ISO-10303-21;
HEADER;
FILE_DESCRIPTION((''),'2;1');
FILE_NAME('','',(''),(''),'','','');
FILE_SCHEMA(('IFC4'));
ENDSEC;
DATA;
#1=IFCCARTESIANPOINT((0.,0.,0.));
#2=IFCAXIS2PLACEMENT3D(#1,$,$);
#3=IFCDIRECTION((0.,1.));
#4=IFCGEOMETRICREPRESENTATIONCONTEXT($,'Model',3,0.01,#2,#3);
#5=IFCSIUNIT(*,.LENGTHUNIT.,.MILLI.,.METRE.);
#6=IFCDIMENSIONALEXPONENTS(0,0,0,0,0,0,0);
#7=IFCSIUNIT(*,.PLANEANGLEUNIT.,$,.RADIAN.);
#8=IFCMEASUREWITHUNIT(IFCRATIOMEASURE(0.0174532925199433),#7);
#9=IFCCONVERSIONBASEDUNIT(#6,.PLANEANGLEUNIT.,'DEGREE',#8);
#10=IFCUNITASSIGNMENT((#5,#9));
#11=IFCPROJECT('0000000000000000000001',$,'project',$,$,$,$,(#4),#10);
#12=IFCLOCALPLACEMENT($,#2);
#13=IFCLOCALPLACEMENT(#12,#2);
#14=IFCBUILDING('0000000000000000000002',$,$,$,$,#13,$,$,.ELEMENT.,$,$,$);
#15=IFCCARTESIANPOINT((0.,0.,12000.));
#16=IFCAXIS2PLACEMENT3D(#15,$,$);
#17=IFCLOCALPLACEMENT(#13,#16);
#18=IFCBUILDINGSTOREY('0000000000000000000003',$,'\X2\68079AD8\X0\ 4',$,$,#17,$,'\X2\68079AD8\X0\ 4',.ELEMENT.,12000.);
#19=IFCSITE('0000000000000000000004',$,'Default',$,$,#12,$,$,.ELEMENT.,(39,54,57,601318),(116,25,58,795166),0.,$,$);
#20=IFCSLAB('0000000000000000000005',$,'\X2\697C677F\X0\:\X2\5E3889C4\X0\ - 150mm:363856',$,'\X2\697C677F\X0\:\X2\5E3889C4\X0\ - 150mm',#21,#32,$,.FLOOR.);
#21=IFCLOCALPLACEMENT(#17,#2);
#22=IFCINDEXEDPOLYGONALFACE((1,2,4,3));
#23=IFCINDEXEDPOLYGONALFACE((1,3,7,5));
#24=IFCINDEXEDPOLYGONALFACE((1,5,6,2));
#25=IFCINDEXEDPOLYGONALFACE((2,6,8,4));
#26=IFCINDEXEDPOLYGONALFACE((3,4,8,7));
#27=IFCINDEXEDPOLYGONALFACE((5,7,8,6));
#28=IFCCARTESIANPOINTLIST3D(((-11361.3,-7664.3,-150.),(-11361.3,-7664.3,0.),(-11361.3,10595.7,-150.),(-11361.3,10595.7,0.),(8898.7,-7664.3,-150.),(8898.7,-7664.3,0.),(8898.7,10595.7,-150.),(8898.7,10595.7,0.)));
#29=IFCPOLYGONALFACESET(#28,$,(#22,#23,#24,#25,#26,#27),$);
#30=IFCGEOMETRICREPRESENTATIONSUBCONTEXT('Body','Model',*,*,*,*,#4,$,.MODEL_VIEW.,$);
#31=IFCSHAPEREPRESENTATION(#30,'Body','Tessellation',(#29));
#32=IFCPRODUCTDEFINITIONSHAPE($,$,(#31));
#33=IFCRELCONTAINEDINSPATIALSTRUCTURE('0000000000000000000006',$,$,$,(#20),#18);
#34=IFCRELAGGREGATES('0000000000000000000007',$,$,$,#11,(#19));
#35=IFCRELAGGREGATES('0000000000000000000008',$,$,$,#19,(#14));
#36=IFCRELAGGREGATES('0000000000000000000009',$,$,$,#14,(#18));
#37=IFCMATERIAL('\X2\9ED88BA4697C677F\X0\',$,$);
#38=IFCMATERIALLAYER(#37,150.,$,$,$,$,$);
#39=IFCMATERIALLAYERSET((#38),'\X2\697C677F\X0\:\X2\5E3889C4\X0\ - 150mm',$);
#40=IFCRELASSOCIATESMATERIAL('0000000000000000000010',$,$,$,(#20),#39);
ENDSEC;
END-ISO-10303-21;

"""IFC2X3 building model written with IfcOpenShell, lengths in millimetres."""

from ifc_helpers import new_model, entity, si_unit, converted_unit, direction, frame, frame_2d, origin, place, context, subcontext, project, spatial, rectangle, extrude, material, layer, layer_set, layer_usage, element, save


model = new_model("IFC2X3")

# Units and contexts
model_context = context("Model", 3, precision=0.01, world=origin(), true_north=direction((0.0, 1.0)))
body_context = subcontext(model_context, "Body", "Model", "MODEL_VIEW")
ifc_project = project(units=[si_unit("LENGTHUNIT", "METRE", prefix="MILLI"), converted_unit("PLANEANGLEUNIT", "DEGREE", entity("IfcRatioMeasure", 0.0174532925199433), si_unit("PLANEANGLEUNIT", "RADIAN"), dimensions=[0, 0, 0, 0, 0, 0, 0])], contexts=[model_context])

# Site, building, storey
site_placement = place(None, origin())
site = spatial("IfcSite", under=ifc_project, at=site_placement, Name="Default", CompositionType="ELEMENT", RefLatitude=(39, 54, 57, 601318), RefLongitude=(116, 25, 58, 795166), RefElevation=0.0)
building_placement = place(site_placement, origin())
building = spatial("IfcBuilding", under=site, at=building_placement, CompositionType="ELEMENT")
storey_placement = place(building_placement, frame((0.0, 0.0, 12000.0)))
storey = spatial("IfcBuildingStorey", under=building, at=storey_placement, Name="标高 4", LongName="标高 4", CompositionType="ELEMENT", Elevation=12000.0)

# Slab
ifc_material_1 = material(Name="默认楼板")
ifc_layer = layer(ifc_material_1, 150.0)
ifc_layer_set = layer_set([ifc_layer], Name="楼板:常规 - 150mm")
ifc_layer_usage = layer_usage(ifc_layer_set, "AXIS3", "POSITIVE", 0.0)
slab_placement = place(storey_placement, origin())
element("IfcSlab", 1, at=slab_placement, inside=storey, material=ifc_layer_usage, Name="楼板:常规 - 150mm:363856", ObjectType="楼板:常规 - 150mm", PredefinedType="FLOOR", context=body_context, shape_type="SweptSolid", body=[
    extrude(rectangle(XDim=18260.0, YDim=20260.0, at=frame_2d((0.0, 0.0), x_axis=(1.0, 0.0))), frame((-1231.3, 1465.7, 0.0), z_axis=(0.0, 0.0, -1.0), x_axis=(0.0, 1.0, 0.0)), (0.0, 0.0, 1.0), 150.0),
])

save(model, "model.ifc")
